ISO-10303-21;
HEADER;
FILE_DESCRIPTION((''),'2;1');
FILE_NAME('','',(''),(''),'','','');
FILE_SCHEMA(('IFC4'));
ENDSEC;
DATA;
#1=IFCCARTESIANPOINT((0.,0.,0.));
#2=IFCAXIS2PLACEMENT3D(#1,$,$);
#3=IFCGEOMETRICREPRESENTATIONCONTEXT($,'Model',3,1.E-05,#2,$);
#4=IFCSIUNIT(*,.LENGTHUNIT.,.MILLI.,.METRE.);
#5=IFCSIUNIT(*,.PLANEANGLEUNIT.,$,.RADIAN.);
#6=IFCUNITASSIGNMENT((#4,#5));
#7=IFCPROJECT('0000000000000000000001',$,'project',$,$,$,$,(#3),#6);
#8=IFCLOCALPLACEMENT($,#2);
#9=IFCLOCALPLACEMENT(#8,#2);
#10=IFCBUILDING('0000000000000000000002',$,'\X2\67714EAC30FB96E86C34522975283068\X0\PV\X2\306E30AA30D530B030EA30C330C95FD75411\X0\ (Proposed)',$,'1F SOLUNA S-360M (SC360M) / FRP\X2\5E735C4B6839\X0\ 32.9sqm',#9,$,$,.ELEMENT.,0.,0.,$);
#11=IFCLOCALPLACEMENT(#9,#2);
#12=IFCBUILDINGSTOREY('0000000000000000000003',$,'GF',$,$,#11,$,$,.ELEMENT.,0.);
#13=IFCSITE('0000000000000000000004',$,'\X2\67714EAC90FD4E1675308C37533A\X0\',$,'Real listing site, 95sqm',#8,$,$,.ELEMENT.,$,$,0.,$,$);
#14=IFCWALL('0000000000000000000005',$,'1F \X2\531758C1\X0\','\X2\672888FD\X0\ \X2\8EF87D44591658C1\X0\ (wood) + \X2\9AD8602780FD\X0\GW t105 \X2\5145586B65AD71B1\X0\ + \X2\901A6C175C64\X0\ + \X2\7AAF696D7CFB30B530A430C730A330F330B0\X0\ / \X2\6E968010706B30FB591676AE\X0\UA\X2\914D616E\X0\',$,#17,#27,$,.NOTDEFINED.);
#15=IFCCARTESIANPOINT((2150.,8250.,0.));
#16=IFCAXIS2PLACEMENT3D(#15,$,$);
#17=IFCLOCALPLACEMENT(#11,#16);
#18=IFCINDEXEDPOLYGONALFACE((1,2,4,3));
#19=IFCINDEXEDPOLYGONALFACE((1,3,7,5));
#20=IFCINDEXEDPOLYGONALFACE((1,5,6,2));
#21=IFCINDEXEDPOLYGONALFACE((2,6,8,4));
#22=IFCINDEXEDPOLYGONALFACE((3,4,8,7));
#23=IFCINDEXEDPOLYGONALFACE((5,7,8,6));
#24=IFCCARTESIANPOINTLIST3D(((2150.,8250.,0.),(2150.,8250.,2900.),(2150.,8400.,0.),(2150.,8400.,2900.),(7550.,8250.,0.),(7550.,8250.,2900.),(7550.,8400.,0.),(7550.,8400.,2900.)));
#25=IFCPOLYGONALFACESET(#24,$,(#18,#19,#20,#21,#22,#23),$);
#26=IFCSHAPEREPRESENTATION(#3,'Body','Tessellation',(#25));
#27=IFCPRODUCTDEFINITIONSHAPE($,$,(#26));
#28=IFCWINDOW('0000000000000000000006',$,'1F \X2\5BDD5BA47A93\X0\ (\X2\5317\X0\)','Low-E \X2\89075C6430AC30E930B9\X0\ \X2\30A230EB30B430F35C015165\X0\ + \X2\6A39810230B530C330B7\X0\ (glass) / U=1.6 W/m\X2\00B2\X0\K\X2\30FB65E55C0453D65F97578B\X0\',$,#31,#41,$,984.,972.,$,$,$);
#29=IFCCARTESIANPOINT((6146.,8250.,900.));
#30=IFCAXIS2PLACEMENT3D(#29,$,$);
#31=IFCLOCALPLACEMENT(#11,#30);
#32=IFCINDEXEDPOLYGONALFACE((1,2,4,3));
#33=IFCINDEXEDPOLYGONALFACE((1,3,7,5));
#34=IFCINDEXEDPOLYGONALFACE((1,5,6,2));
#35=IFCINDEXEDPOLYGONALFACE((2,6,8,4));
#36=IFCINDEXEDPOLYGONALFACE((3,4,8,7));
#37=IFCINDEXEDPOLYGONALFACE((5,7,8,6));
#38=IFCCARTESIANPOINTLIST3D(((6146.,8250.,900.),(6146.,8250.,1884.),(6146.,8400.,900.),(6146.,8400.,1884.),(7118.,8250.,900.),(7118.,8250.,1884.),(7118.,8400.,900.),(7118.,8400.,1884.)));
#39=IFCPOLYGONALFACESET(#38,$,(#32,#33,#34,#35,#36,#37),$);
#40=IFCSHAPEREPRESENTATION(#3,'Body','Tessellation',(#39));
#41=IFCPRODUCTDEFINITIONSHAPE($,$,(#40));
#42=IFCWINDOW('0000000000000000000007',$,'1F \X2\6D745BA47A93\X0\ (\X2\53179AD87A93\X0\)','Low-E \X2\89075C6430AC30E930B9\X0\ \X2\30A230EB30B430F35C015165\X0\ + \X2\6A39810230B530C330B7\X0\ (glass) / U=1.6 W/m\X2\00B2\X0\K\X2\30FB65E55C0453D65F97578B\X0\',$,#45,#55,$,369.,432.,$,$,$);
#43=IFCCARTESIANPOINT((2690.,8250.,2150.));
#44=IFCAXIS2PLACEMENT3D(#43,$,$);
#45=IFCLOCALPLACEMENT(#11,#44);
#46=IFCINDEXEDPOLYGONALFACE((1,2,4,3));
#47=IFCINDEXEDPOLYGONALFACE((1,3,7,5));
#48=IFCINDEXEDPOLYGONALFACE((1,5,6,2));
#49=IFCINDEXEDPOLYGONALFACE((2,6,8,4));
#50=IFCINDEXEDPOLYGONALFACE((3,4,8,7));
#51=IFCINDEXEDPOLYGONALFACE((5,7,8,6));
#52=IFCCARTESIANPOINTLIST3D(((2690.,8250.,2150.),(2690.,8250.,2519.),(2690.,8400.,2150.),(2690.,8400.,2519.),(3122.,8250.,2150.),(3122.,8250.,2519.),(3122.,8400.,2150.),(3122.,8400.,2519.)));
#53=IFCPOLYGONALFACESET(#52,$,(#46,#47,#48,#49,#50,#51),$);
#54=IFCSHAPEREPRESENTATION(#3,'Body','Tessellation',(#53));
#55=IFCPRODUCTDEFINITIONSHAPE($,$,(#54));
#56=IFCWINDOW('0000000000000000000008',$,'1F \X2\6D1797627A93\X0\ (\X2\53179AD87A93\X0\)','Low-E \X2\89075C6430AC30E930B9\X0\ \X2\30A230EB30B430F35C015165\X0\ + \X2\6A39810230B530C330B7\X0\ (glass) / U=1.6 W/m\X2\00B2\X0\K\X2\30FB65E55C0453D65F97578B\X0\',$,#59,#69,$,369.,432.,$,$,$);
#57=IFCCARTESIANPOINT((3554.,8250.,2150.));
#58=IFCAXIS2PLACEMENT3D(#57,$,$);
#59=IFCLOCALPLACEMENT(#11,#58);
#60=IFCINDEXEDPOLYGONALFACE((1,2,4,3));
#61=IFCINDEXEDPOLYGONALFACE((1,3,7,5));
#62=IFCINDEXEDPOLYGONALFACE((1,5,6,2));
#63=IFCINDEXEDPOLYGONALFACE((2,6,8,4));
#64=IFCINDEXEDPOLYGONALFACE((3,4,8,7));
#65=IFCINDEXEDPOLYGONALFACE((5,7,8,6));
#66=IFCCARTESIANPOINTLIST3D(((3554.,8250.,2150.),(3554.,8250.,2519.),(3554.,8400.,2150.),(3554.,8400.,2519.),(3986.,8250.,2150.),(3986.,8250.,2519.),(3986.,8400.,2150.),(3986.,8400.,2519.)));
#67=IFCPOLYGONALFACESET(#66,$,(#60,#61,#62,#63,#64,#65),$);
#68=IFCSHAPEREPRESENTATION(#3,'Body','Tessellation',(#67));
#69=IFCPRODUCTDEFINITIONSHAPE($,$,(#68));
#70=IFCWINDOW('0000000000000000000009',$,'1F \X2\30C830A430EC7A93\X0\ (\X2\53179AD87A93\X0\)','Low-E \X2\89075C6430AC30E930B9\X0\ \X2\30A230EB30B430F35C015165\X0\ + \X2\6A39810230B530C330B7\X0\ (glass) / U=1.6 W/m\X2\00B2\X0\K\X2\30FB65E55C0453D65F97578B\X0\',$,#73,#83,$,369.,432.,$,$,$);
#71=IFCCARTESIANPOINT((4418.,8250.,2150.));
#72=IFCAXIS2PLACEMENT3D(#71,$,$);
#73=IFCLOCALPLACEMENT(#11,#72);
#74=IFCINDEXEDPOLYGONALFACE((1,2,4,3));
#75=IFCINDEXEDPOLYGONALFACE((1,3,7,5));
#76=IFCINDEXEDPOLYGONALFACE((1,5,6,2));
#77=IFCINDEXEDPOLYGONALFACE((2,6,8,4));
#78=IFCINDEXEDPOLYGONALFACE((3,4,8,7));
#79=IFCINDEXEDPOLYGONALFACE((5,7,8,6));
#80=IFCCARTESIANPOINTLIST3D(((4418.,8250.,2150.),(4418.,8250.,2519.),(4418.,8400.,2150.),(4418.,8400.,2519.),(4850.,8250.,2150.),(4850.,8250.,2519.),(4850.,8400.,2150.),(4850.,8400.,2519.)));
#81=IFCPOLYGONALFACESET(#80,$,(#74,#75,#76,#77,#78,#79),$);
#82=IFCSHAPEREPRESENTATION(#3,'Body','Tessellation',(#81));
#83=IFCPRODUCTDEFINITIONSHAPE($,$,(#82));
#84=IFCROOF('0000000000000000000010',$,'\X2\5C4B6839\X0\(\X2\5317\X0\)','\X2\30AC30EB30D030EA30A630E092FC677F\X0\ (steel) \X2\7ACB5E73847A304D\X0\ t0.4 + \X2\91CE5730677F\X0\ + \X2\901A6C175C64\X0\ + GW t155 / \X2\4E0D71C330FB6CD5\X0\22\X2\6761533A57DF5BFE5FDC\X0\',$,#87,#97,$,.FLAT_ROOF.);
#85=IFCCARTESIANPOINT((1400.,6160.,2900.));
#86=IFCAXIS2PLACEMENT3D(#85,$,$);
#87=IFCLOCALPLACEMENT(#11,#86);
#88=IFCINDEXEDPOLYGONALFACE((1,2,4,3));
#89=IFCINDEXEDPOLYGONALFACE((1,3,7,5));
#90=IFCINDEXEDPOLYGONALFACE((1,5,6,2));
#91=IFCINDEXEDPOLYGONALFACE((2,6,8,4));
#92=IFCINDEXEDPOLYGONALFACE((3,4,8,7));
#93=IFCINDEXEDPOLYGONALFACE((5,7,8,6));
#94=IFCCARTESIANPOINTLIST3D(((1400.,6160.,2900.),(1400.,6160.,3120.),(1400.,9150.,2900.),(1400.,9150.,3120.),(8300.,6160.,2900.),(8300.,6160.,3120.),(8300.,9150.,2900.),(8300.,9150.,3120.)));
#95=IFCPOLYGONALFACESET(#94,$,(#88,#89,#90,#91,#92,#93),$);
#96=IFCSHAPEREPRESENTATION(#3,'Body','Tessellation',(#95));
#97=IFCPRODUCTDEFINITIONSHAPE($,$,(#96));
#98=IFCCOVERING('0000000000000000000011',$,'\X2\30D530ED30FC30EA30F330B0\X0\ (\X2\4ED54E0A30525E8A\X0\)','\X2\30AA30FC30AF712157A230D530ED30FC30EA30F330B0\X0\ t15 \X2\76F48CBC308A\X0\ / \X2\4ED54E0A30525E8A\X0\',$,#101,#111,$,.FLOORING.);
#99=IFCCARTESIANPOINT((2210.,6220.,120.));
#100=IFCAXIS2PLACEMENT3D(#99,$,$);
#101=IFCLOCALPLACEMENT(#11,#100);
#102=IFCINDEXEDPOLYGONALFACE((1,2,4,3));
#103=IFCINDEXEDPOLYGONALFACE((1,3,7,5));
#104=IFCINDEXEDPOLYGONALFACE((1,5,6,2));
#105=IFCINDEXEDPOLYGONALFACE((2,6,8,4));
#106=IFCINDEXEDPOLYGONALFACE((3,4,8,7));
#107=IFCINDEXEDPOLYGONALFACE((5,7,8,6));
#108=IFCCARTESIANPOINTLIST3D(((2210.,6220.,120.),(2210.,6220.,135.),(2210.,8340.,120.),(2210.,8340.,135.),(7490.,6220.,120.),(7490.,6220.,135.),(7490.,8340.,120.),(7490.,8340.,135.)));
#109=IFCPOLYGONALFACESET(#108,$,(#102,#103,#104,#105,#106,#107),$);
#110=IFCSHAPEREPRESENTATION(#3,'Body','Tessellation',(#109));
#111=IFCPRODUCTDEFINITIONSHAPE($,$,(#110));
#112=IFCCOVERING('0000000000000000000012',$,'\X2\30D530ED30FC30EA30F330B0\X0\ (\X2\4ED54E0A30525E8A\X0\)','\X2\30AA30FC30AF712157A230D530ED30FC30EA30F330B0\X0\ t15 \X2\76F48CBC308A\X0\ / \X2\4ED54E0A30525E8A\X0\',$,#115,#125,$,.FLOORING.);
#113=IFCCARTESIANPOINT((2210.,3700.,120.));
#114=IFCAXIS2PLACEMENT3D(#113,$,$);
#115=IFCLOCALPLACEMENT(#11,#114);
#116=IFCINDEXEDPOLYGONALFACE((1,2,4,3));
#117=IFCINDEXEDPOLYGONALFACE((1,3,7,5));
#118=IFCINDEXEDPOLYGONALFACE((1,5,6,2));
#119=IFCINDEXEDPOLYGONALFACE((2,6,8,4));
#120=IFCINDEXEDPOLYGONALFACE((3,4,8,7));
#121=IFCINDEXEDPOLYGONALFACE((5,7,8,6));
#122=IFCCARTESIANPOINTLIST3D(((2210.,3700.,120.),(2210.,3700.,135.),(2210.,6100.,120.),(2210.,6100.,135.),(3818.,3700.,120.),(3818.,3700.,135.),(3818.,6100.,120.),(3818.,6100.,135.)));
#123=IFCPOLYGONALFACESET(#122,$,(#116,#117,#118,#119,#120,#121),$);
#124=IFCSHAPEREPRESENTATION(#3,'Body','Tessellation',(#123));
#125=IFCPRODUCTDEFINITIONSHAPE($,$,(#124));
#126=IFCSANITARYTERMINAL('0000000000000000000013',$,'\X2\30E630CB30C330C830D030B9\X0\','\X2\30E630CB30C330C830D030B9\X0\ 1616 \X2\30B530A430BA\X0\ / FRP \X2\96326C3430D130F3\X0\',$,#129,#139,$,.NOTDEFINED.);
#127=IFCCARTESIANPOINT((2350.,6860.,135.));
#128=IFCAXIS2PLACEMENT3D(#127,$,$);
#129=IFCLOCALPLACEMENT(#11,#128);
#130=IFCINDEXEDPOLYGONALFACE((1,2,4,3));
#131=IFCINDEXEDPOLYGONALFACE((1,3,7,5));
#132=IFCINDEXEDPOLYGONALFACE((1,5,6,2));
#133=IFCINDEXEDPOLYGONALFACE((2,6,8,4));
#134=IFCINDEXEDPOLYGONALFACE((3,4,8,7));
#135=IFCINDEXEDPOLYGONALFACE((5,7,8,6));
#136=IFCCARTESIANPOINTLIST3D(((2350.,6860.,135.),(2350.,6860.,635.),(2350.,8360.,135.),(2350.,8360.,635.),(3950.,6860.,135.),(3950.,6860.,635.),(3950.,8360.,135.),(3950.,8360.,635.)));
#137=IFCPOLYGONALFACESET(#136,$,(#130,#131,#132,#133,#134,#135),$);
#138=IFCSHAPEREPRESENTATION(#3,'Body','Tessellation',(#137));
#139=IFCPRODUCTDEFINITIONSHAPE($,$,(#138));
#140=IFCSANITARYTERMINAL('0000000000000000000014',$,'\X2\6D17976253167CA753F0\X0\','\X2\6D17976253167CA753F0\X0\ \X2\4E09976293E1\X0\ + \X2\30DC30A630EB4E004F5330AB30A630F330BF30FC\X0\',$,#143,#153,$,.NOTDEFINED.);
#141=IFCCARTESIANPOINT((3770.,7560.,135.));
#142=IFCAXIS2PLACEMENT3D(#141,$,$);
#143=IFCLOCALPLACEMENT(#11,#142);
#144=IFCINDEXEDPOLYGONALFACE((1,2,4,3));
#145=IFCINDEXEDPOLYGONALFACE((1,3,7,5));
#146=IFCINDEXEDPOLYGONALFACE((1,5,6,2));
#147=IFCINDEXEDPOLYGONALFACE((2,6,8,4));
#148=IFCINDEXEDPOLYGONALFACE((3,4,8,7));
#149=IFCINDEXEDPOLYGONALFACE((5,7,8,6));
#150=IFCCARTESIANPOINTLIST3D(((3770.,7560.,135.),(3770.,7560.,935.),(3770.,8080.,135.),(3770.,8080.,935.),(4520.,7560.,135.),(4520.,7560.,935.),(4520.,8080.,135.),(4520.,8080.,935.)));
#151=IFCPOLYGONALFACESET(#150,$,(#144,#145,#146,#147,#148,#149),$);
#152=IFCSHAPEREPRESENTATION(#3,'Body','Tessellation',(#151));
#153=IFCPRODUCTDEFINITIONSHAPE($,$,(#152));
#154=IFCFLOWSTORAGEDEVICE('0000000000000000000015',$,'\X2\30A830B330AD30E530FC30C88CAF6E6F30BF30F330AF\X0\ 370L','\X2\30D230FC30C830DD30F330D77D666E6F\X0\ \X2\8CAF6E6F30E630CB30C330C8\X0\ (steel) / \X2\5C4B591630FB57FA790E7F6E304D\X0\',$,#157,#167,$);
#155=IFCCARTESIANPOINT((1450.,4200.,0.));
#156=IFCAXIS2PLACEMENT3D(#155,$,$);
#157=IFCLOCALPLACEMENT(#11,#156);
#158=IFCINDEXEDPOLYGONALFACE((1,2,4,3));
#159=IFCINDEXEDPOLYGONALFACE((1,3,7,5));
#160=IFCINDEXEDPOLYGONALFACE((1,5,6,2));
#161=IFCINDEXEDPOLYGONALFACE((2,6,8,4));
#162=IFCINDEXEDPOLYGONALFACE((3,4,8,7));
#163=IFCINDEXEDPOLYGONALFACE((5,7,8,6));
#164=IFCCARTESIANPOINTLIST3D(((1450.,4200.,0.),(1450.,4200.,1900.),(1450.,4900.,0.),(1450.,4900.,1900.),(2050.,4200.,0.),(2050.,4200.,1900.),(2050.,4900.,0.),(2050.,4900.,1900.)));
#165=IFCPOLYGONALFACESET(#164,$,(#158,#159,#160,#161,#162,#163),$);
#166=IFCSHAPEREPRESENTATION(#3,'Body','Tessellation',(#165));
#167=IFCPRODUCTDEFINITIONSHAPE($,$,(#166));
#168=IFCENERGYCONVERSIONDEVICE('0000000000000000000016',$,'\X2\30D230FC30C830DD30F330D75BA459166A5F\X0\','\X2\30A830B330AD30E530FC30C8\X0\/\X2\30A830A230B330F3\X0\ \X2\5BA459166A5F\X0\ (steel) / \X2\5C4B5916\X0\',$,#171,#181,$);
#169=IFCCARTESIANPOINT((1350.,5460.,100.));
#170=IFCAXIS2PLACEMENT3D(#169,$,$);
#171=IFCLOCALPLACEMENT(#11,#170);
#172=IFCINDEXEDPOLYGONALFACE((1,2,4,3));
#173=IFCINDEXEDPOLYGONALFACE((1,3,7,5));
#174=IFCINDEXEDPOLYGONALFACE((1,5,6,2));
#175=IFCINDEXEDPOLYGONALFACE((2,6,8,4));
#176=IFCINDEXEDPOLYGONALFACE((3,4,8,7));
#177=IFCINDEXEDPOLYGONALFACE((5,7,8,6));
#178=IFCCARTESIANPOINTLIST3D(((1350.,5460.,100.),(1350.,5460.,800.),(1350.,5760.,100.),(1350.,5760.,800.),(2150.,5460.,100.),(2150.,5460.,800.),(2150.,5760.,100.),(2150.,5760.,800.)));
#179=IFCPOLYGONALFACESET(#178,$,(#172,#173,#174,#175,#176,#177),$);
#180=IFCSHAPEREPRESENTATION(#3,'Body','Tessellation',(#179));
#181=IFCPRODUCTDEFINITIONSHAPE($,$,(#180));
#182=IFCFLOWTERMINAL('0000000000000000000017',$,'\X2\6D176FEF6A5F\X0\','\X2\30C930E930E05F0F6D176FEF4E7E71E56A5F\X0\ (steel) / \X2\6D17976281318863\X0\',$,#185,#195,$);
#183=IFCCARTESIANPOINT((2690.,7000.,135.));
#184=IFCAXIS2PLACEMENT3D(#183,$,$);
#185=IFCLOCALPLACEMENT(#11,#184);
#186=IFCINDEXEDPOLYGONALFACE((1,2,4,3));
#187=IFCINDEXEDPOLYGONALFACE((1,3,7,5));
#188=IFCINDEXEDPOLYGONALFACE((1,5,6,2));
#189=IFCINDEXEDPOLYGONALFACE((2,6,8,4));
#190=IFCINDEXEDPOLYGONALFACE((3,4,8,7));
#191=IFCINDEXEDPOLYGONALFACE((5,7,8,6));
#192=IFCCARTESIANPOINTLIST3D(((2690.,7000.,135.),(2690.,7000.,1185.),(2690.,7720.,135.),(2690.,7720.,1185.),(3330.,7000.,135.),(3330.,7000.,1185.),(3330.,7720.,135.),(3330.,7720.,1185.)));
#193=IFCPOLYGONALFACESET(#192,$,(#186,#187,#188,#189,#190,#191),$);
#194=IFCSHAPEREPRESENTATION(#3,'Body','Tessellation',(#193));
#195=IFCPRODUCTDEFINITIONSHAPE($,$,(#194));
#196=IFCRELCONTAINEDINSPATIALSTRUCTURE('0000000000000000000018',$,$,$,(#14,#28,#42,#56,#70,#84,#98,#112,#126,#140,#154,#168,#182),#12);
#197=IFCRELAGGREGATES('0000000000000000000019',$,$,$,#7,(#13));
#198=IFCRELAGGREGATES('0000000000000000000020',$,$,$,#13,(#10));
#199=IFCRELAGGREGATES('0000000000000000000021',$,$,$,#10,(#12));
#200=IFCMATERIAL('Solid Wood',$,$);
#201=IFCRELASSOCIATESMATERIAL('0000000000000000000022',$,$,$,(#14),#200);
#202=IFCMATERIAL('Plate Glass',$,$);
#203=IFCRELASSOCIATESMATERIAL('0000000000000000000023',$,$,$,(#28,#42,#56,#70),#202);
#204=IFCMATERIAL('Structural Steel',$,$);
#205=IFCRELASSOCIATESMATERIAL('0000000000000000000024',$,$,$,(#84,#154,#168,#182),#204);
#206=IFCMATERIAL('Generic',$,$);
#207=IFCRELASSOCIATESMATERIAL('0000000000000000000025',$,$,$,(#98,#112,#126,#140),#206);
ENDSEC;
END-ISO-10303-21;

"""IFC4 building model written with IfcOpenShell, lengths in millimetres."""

from ifc_helpers import new_model, si_unit, frame, frame_2d, origin, place, context, project, spatial, rectangle, extrude, material, element, fill, save


model = new_model("IFC4")

# Units and contexts
model_context = context("Model", 3, precision=1e-05, world=origin())
ifc_project = project(units=[si_unit("LENGTHUNIT", "METRE", prefix="MILLI"), si_unit("PLANEANGLEUNIT", "RADIAN")], contexts=[model_context])

# Site, building, storey
site_placement = place(None, origin())
site = spatial("IfcSite", under=ifc_project, at=site_placement, Name="東京都世田谷区", ObjectType="Real listing site, 95sqm", CompositionType="ELEMENT", RefElevation=0.0)
building_placement = place(site_placement, origin())
building = spatial("IfcBuilding", under=site, at=building_placement, Name="東京・雨水利用とPVのオフグリッド志向 (Proposed)", ObjectType="1F SOLUNA S-360M (SC360M) / FRP平屋根 32.9sqm", CompositionType="ELEMENT", ElevationOfRefHeight=0.0, ElevationOfTerrain=0.0)
storey_placement = place(building_placement, origin())
storey = spatial("IfcBuildingStorey", under=building, at=storey_placement, Name="GF", CompositionType="ELEMENT", Elevation=0.0)

# Shared definitions
ifc_material_1 = material(Name="Solid Wood")

# Wall, openings, windows
wall_1_placement = place(storey_placement, frame((2150.0, 8250.0, 0.0)))
wall_1 = element("IfcWall", 1, at=wall_1_placement, inside=storey, material=ifc_material_1, Name="1F 北壁", Description="木製 軸組外壁 (wood) + 高性能GW t105 充填断熱 + 通気層 + 窯業系サイディング / 準耐火・外皮UA配慮", PredefinedType="NOTDEFINED", context=model_context, shape_type="SweptSolid", body=[
    extrude(rectangle(XDim=5400.0, YDim=150.0, at=frame_2d((2700.0, 75.0))), frame((2150.0, 8250.0, 0.0)), (0.0, 0.0, 1.0), 2900.0),
])
opening_1_placement = place(storey_placement, frame((6146.0, 8250.0, 900.0)))
opening_1 = element("IfcOpeningElement", 2, at=opening_1_placement, cuts=wall_1, PredefinedType="NOTDEFINED", context=model_context, shape_type="SweptSolid", body=[
    extrude(rectangle(XDim=972.0, YDim=150.0, at=frame_2d((486.0, 75.0))), frame((6146.0, 8250.0, 900.0)), (0.0, 0.0, 1.0), 984.0),
])
opening_2_placement = place(storey_placement, frame((2690.0, 8250.0, 2150.0)))
opening_2 = element("IfcOpeningElement", 3, at=opening_2_placement, cuts=wall_1, PredefinedType="NOTDEFINED", context=model_context, shape_type="SweptSolid", body=[
    extrude(rectangle(XDim=432.0, YDim=150.0, at=frame_2d((216.0, 75.0))), frame((2690.0, 8250.0, 2150.0)), (0.0, 0.0, 1.0), 369.0),
])
opening_3_placement = place(storey_placement, frame((3554.0, 8250.0, 2150.0)))
opening_3 = element("IfcOpeningElement", 4, at=opening_3_placement, cuts=wall_1, PredefinedType="NOTDEFINED", context=model_context, shape_type="SweptSolid", body=[
    extrude(rectangle(XDim=432.0, YDim=150.0, at=frame_2d((216.0, 75.0))), frame((3554.0, 8250.0, 2150.0)), (0.0, 0.0, 1.0), 369.0),
])
opening_4_placement = place(storey_placement, frame((4418.0, 8250.0, 2150.0)))
opening_4 = element("IfcOpeningElement", 5, at=opening_4_placement, cuts=wall_1, PredefinedType="NOTDEFINED", context=model_context, shape_type="SweptSolid", body=[
    extrude(rectangle(XDim=432.0, YDim=150.0, at=frame_2d((216.0, 75.0))), frame((4418.0, 8250.0, 2150.0)), (0.0, 0.0, 1.0), 369.0),
])
ifc_material_2 = material(Name="Plate Glass")
window_1_placement = place(storey_placement, frame((6146.0, 8250.0, 900.0)))
window_1 = element("IfcWindow", 6, at=window_1_placement, inside=storey, material=ifc_material_2, Name="1F 寝室窓 (北)", Description="Low-E 複層ガラス アルゴン封入 + 樹脂サッシ (glass) / U=1.6 W/m²K・日射取得型", OverallHeight=984.0, OverallWidth=972.0, context=model_context, shape_type="SweptSolid", body=[
    extrude(rectangle(XDim=972.0, YDim=150.0, at=frame_2d((486.0, 75.0))), frame((6146.0, 8250.0, 900.0)), (0.0, 0.0, 1.0), 984.0),
])
fill(opening_1, window_1)
window_2_placement = place(storey_placement, frame((2690.0, 8250.0, 2150.0)))
window_2 = element("IfcWindow", 7, at=window_2_placement, inside=storey, material=ifc_material_2, Name="1F 浴室窓 (北高窓)", Description="Low-E 複層ガラス アルゴン封入 + 樹脂サッシ (glass) / U=1.6 W/m²K・日射取得型", OverallHeight=369.0, OverallWidth=432.0, context=model_context, shape_type="SweptSolid", body=[
    extrude(rectangle(XDim=432.0, YDim=150.0, at=frame_2d((216.0, 75.0))), frame((2690.0, 8250.0, 2150.0)), (0.0, 0.0, 1.0), 369.0),
])
fill(opening_2, window_2)
window_3_placement = place(storey_placement, frame((3554.0, 8250.0, 2150.0)))
window_3 = element("IfcWindow", 8, at=window_3_placement, inside=storey, material=ifc_material_2, Name="1F 洗面窓 (北高窓)", Description="Low-E 複層ガラス アルゴン封入 + 樹脂サッシ (glass) / U=1.6 W/m²K・日射取得型", OverallHeight=369.0, OverallWidth=432.0, context=model_context, shape_type="SweptSolid", body=[
    extrude(rectangle(XDim=432.0, YDim=150.0, at=frame_2d((216.0, 75.0))), frame((3554.0, 8250.0, 2150.0)), (0.0, 0.0, 1.0), 369.0),
])
fill(opening_3, window_3)
window_4_placement = place(storey_placement, frame((4418.0, 8250.0, 2150.0)))
window_4 = element("IfcWindow", 9, at=window_4_placement, inside=storey, material=ifc_material_2, Name="1F トイレ窓 (北高窓)", Description="Low-E 複層ガラス アルゴン封入 + 樹脂サッシ (glass) / U=1.6 W/m²K・日射取得型", OverallHeight=369.0, OverallWidth=432.0, context=model_context, shape_type="SweptSolid", body=[
    extrude(rectangle(XDim=432.0, YDim=150.0, at=frame_2d((216.0, 75.0))), frame((4418.0, 8250.0, 2150.0)), (0.0, 0.0, 1.0), 369.0),
])
fill(opening_4, window_4)

# Roof
ifc_material_3 = material(Name="Structural Steel")
roof_placement = place(storey_placement, frame((1400.0, 6160.0, 2900.0)))
element("IfcRoof", 10, at=roof_placement, inside=storey, material=ifc_material_3, Name="屋根(北)", Description="ガルバリウム鋼板 (steel) 立平葺き t0.4 + 野地板 + 通気層 + GW t155 / 不燃・法22条区域対応", PredefinedType="FLAT_ROOF", context=model_context, shape_type="SweptSolid", body=[
    extrude(rectangle(XDim=6900.0, YDim=2990.0, at=frame_2d((3450.0, 1495.0))), frame((1400.0, 6160.0, 2900.0)), (0.0, 0.0, 1.0), 220.0),
])

# Coverings
ifc_material_4 = material(Name="Generic")
covering_1_placement = place(storey_placement, frame((2210.0, 6220.0, 120.0)))
element("IfcCovering", 11, at=covering_1_placement, inside=storey, material=ifc_material_4, Name="フローリング (仕上げ床)", Description="オーク無垢フローリング t15 直貼り / 仕上げ床", PredefinedType="FLOORING", context=model_context, shape_type="SweptSolid", body=[
    extrude(rectangle(XDim=5280.0, YDim=2120.0, at=frame_2d((2640.0, 1060.0))), frame((2210.0, 6220.0, 120.0)), (0.0, 0.0, 1.0), 15.0),
])
covering_2_placement = place(storey_placement, frame((2210.0, 3700.0, 120.0)))
element("IfcCovering", 12, at=covering_2_placement, inside=storey, material=ifc_material_4, Name="フローリング (仕上げ床)", Description="オーク無垢フローリング t15 直貼り / 仕上げ床", PredefinedType="FLOORING", context=model_context, shape_type="SweptSolid", body=[
    extrude(rectangle(XDim=1608.0, YDim=2400.0, at=frame_2d((804.0, 1200.0))), frame((2210.0, 3700.0, 120.0)), (0.0, 0.0, 1.0), 15.0),
])

# Sanitary terminals
sanitary_terminal_1_placement = place(storey_placement, frame((2350.0, 6860.0, 135.0)))
element("IfcSanitaryTerminal", 13, at=sanitary_terminal_1_placement, inside=storey, material=ifc_material_4, Name="ユニットバス", Description="ユニットバス 1616 サイズ / FRP 防水パン", PredefinedType="NOTDEFINED", context=model_context, shape_type="SweptSolid", body=[
    extrude(rectangle(XDim=1600.0, YDim=1500.0, at=frame_2d((800.0, 750.0))), frame((2350.0, 6860.0, 135.0)), (0.0, 0.0, 1.0), 500.0),
])
sanitary_terminal_2_placement = place(storey_placement, frame((3770.0, 7560.0, 135.0)))
element("IfcSanitaryTerminal", 14, at=sanitary_terminal_2_placement, inside=storey, material=ifc_material_4, Name="洗面化粧台", Description="洗面化粧台 三面鏡 + ボウル一体カウンター", PredefinedType="NOTDEFINED", context=model_context, shape_type="SweptSolid", body=[
    extrude(rectangle(XDim=750.0, YDim=520.0, at=frame_2d((375.0, 260.0))), frame((3770.0, 7560.0, 135.0)), (0.0, 0.0, 1.0), 800.0),
])

# Flow storage device
flow_storage_device_placement = place(storey_placement, frame((1450.0, 4200.0, 0.0)))
element("IfcFlowStorageDevice", 15, at=flow_storage_device_placement, inside=storey, material=ifc_material_3, Name="エコキュート貯湯タンク 370L", Description="ヒートポンプ給湯 貯湯ユニット (steel) / 屋外・基礎置き", context=model_context, shape_type="SweptSolid", body=[
    extrude(rectangle(XDim=600.0, YDim=700.0, at=frame_2d((300.0, 350.0))), frame((1450.0, 4200.0, 0.0)), (0.0, 0.0, 1.0), 1900.0),
])

# Energy conversion device
energy_conversion_device_placement = place(storey_placement, frame((1350.0, 5460.0, 100.0)))
element("IfcEnergyConversionDevice", 16, at=energy_conversion_device_placement, inside=storey, material=ifc_material_3, Name="ヒートポンプ室外機", Description="エコキュート/エアコン 室外機 (steel) / 屋外", context=model_context, shape_type="SweptSolid", body=[
    extrude(rectangle(XDim=800.0, YDim=300.0, at=frame_2d((400.0, 150.0))), frame((1350.0, 5460.0, 100.0)), (0.0, 0.0, 1.0), 700.0),
])

# Flow terminal
flow_terminal_placement = place(storey_placement, frame((2690.0, 7000.0, 135.0)))
element("IfcFlowTerminal", 17, at=flow_terminal_placement, inside=storey, material=ifc_material_3, Name="洗濯機", Description="ドラム式洗濯乾燥機 (steel) / 洗面脱衣", context=model_context, shape_type="SweptSolid", body=[
    extrude(rectangle(XDim=640.0, YDim=720.0, at=frame_2d((320.0, 360.0))), frame((2690.0, 7000.0, 135.0)), (0.0, 0.0, 1.0), 1050.0),
])

save(model, "model.ifc")
